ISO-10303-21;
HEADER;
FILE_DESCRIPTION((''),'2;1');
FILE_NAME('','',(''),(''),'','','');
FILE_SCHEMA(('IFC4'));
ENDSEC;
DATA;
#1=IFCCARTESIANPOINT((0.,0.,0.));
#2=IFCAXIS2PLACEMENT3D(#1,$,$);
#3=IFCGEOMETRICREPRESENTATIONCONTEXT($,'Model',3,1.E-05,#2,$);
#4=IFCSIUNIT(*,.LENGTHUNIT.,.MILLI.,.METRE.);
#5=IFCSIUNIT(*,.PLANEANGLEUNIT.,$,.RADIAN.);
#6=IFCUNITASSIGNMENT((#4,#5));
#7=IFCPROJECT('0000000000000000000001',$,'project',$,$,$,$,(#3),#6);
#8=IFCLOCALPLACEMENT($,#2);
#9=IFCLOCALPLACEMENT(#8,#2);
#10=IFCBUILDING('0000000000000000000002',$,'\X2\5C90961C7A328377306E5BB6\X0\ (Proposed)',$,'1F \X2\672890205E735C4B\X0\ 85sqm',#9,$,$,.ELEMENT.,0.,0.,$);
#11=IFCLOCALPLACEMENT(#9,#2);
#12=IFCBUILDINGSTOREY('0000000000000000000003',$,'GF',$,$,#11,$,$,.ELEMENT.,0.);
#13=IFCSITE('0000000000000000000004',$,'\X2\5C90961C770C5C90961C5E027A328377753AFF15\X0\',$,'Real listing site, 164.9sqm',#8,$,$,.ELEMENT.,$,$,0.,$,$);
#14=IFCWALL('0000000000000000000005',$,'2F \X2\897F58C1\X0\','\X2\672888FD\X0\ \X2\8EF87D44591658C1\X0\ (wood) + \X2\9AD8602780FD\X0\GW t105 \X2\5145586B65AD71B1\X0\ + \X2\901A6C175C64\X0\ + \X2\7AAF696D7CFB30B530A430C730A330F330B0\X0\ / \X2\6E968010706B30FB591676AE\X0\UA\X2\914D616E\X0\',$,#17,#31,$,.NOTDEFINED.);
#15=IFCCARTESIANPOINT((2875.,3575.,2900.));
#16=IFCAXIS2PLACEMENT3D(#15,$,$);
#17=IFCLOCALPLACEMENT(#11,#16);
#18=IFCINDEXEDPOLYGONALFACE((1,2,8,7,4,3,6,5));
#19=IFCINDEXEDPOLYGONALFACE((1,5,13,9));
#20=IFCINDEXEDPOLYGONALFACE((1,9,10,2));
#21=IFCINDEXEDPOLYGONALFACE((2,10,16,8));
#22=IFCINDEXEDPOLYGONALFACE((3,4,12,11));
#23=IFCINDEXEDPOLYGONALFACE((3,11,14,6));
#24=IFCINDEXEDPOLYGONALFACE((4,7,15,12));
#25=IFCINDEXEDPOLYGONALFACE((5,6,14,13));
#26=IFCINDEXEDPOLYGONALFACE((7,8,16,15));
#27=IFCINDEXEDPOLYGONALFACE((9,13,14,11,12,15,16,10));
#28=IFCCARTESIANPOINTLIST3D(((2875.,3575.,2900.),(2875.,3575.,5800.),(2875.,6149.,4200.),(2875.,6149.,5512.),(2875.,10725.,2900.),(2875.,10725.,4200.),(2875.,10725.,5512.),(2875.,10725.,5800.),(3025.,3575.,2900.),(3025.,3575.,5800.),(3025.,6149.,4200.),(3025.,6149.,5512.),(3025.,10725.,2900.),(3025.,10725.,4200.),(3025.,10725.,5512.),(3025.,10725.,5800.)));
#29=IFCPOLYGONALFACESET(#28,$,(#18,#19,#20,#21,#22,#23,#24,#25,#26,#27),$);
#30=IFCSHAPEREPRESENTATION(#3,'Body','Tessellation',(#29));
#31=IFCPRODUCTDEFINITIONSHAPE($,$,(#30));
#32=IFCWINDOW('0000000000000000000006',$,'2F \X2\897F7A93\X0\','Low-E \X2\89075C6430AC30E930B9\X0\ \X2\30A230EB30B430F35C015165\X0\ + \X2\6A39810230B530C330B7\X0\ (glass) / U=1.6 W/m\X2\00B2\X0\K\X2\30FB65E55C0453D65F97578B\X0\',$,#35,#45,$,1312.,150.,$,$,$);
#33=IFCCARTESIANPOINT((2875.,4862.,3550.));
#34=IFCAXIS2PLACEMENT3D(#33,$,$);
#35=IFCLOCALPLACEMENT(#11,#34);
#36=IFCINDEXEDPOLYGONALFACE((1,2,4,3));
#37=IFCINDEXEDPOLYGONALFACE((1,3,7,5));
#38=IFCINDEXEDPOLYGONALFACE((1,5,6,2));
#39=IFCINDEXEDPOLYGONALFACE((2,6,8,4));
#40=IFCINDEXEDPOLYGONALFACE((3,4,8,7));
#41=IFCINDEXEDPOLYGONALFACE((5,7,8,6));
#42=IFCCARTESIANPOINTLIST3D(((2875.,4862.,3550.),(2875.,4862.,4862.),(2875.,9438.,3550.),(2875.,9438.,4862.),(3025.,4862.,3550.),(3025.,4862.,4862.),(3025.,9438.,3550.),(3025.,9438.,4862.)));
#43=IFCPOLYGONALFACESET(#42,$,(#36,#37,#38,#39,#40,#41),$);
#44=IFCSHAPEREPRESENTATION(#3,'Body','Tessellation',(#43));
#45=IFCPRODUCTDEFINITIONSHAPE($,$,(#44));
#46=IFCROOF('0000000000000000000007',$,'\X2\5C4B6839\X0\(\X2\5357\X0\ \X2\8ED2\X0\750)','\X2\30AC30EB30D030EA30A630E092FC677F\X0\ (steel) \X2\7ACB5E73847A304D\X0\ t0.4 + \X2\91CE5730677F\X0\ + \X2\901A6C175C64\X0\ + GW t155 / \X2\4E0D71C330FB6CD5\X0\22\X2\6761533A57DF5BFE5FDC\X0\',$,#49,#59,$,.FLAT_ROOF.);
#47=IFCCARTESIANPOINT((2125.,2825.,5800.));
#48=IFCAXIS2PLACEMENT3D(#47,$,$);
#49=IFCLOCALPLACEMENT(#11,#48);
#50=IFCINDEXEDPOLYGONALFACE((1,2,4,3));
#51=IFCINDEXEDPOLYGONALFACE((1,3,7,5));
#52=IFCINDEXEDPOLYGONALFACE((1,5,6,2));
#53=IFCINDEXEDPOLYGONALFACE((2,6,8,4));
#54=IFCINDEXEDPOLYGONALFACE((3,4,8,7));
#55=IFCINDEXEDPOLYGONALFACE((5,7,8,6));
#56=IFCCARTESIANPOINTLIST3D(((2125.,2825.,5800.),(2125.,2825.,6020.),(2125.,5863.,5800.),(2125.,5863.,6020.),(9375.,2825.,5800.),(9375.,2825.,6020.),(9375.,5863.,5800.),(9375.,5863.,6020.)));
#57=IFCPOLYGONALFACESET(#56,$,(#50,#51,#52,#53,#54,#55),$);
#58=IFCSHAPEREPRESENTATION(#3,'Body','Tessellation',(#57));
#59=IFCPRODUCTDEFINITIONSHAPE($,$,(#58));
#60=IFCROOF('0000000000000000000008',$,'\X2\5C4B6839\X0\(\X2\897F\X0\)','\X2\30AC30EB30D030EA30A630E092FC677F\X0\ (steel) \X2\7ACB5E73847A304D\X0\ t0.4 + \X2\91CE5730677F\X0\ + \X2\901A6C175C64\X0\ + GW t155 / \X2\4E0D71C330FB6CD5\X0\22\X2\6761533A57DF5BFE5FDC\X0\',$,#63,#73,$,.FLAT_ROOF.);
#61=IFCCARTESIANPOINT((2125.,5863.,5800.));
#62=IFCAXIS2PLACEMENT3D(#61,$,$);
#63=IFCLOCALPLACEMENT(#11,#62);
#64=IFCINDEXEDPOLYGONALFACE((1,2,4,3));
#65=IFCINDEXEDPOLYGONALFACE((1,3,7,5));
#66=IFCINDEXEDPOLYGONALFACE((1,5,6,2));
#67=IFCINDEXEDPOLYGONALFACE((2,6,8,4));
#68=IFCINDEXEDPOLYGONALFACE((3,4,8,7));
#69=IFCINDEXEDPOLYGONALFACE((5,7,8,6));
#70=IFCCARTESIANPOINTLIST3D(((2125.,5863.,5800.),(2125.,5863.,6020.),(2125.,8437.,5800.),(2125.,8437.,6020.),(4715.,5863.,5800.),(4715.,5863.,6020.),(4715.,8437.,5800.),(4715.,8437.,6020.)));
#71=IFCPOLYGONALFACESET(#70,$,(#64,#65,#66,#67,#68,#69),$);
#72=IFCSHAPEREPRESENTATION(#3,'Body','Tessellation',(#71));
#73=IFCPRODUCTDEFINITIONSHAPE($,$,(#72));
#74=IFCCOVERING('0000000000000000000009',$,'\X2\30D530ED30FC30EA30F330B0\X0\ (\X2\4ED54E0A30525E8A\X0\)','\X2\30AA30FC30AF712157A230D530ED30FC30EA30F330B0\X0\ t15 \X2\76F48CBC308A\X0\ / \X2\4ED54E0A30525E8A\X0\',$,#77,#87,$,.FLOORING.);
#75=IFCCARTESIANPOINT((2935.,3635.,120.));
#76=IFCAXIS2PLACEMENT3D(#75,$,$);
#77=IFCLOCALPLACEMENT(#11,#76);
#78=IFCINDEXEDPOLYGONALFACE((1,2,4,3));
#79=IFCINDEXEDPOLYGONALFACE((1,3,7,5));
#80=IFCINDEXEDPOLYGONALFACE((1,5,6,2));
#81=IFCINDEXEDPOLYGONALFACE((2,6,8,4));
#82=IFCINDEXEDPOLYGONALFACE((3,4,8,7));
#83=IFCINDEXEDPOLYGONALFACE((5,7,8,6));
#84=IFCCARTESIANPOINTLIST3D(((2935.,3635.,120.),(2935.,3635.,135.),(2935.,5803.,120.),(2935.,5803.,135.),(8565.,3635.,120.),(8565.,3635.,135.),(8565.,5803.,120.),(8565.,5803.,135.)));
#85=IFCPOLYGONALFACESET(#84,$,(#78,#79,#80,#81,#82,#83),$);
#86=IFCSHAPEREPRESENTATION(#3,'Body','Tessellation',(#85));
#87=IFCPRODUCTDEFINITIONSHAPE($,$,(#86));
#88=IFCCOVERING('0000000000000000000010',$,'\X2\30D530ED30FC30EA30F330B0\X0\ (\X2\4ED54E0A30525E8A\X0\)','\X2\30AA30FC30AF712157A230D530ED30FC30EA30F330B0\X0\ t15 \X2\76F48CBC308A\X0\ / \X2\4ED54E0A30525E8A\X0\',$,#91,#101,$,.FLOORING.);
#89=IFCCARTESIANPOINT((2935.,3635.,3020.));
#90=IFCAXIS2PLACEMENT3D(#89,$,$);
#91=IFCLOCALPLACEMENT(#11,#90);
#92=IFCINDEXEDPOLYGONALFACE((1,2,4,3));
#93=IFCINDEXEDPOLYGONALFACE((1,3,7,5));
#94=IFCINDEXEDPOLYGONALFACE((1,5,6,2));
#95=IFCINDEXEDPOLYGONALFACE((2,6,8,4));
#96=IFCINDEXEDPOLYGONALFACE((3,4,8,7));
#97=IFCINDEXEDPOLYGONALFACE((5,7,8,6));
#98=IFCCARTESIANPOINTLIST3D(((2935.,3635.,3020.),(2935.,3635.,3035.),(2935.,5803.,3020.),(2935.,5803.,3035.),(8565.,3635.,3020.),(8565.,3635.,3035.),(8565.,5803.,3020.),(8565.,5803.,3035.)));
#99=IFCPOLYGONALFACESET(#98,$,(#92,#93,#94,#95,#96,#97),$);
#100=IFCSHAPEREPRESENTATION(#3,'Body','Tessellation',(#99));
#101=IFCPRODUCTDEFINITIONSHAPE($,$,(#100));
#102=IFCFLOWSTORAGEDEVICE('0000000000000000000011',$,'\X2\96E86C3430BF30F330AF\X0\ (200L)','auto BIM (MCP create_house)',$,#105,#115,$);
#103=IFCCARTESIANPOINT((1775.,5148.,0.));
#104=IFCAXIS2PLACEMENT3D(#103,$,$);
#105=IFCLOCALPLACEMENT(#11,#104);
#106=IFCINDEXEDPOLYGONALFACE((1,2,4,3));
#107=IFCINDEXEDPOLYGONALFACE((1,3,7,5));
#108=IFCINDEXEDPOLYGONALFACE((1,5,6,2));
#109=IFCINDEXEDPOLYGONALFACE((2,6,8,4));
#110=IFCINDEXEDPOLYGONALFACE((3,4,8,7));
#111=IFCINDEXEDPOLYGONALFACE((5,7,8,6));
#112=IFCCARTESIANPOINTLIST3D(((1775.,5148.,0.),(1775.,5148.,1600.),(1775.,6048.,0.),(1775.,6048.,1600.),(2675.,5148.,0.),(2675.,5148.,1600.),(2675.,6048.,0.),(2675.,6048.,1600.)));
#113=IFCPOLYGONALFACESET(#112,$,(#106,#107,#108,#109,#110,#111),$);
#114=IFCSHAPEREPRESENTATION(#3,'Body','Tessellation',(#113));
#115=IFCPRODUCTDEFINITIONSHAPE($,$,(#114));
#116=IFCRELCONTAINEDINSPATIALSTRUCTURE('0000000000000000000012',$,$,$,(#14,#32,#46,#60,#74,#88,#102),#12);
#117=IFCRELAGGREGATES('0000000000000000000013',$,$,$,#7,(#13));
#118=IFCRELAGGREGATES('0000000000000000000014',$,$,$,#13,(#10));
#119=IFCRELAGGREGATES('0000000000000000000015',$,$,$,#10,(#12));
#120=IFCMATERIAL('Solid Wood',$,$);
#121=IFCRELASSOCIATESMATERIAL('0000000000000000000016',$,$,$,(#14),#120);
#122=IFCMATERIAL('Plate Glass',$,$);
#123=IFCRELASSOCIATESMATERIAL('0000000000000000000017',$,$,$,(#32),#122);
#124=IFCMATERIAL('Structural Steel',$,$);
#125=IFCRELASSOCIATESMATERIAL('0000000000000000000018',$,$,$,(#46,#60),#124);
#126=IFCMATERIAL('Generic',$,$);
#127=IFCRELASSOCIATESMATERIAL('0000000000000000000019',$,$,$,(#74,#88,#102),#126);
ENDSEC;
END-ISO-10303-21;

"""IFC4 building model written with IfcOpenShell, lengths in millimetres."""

from ifc_helpers import new_model, si_unit, frame, frame_2d, origin, place, context, project, spatial, rectangle, extrude, material, element, fill, save


model = new_model("IFC4")

# Units and contexts
model_context = context("Model", 3, precision=1e-05, world=origin())
ifc_project = project(units=[si_unit("LENGTHUNIT", "METRE", prefix="MILLI"), si_unit("PLANEANGLEUNIT", "RADIAN")], contexts=[model_context])

# Site, building, storey
site_placement = place(None, origin())
site = spatial("IfcSite", under=ifc_project, at=site_placement, Name="岐阜県岐阜市稲荷町５", ObjectType="Real listing site, 164.9sqm", CompositionType="ELEMENT", RefElevation=0.0)
building_placement = place(site_placement, origin())
building = spatial("IfcBuilding", under=site, at=building_placement, Name="岐阜稲荷の家 (Proposed)", ObjectType="1F 木造平屋 85sqm", CompositionType="ELEMENT", ElevationOfRefHeight=0.0, ElevationOfTerrain=0.0)
storey_placement = place(building_placement, origin())
storey = spatial("IfcBuildingStorey", under=building, at=storey_placement, Name="GF", CompositionType="ELEMENT", Elevation=0.0)

# Shared definitions
ifc_material_1 = material(Name="Solid Wood")
ifc_material_2 = material(Name="Generic")

# Shared definitions
ifc_material_3 = material(Name="Plate Glass")

# Wall, opening, window
wall_1_placement = place(storey_placement, frame((2875.0, 3575.0, 2900.0)))
wall_1 = element("IfcWall", 1, at=wall_1_placement, inside=storey, material=ifc_material_1, Name="2F 西壁", Description="木製 軸組外壁 (wood) + 高性能GW t105 充填断熱 + 通気層 + 窯業系サイディング / 準耐火・外皮UA配慮", PredefinedType="NOTDEFINED", context=model_context, shape_type="SweptSolid", body=[
    extrude(rectangle(XDim=150.0, YDim=7150.0, at=frame_2d((75.0, 3575.0))), frame((2875.0, 3575.0, 2900.0)), (0.0, 0.0, 1.0), 2900.0),
])
opening_1_placement = place(storey_placement, frame((2875.0, 4862.0, 3550.0)))
opening_1 = element("IfcOpeningElement", 2, at=opening_1_placement, cuts=wall_1, PredefinedType="NOTDEFINED", context=model_context, shape_type="SweptSolid", body=[
    extrude(rectangle(XDim=150.0, YDim=4576.0, at=frame_2d((75.0, 2288.0))), frame((2875.0, 4862.0, 3550.0)), (0.0, 0.0, 1.0), 1312.0),
])
window_1_placement = place(storey_placement, frame((2875.0, 4862.0, 3550.0)))
window_1 = element("IfcWindow", 3, at=window_1_placement, inside=storey, material=ifc_material_3, Name="2F 西窓", Description="Low-E 複層ガラス アルゴン封入 + 樹脂サッシ (glass) / U=1.6 W/m²K・日射取得型", OverallHeight=1312.0, OverallWidth=150.0, context=model_context, shape_type="SweptSolid", body=[
    extrude(rectangle(XDim=150.0, YDim=4576.0, at=frame_2d((75.0, 2288.0))), frame((2875.0, 4862.0, 3550.0)), (0.0, 0.0, 1.0), 1312.0),
])
fill(opening_1, window_1)

# Roofs
ifc_material_4 = material(Name="Structural Steel")
roof_1_placement = place(storey_placement, frame((2125.0, 2825.0, 5800.0)))
element("IfcRoof", 4, at=roof_1_placement, inside=storey, material=ifc_material_4, Name="屋根(南 軒750)", Description="ガルバリウム鋼板 (steel) 立平葺き t0.4 + 野地板 + 通気層 + GW t155 / 不燃・法22条区域対応", PredefinedType="FLAT_ROOF", context=model_context, shape_type="SweptSolid", body=[
    extrude(rectangle(XDim=7250.0, YDim=3038.0, at=frame_2d((3625.0, 1519.0))), frame((2125.0, 2825.0, 5800.0)), (0.0, 0.0, 1.0), 220.0),
])
roof_2_placement = place(storey_placement, frame((2125.0, 5863.0, 5800.0)))
element("IfcRoof", 5, at=roof_2_placement, inside=storey, material=ifc_material_4, Name="屋根(西)", Description="ガルバリウム鋼板 (steel) 立平葺き t0.4 + 野地板 + 通気層 + GW t155 / 不燃・法22条区域対応", PredefinedType="FLAT_ROOF", context=model_context, shape_type="SweptSolid", body=[
    extrude(rectangle(XDim=2590.0, YDim=2574.0, at=frame_2d((1295.0, 1287.0))), frame((2125.0, 5863.0, 5800.0)), (0.0, 0.0, 1.0), 220.0),
])

# Coverings
covering_1_placement = place(storey_placement, frame((2935.0, 3635.0, 120.0)))
element("IfcCovering", 6, at=covering_1_placement, inside=storey, material=ifc_material_2, Name="フローリング (仕上げ床)", Description="オーク無垢フローリング t15 直貼り / 仕上げ床", PredefinedType="FLOORING", context=model_context, shape_type="SweptSolid", body=[
    extrude(rectangle(XDim=5630.0, YDim=2168.0, at=frame_2d((2815.0, 1084.0))), frame((2935.0, 3635.0, 120.0)), (0.0, 0.0, 1.0), 15.0),
])
covering_2_placement = place(storey_placement, frame((2935.0, 3635.0, 3020.0)))
element("IfcCovering", 7, at=covering_2_placement, inside=storey, material=ifc_material_2, Name="フローリング (仕上げ床)", Description="オーク無垢フローリング t15 直貼り / 仕上げ床", PredefinedType="FLOORING", context=model_context, shape_type="SweptSolid", body=[
    extrude(rectangle(XDim=5630.0, YDim=2168.0, at=frame_2d((2815.0, 1084.0))), frame((2935.0, 3635.0, 3020.0)), (0.0, 0.0, 1.0), 15.0),
])

# Flow storage device
flow_storage_device_placement = place(storey_placement, frame((1775.0, 5148.0, 0.0)))
element("IfcFlowStorageDevice", 8, at=flow_storage_device_placement, inside=storey, material=ifc_material_2, Name="雨水タンク (200L)", Description="auto BIM (MCP create_house)", context=model_context, shape_type="SweptSolid", body=[
    extrude(rectangle(XDim=900.0, YDim=900.0, at=frame_2d((450.0, 450.0))), frame((1775.0, 5148.0, 0.0)), (0.0, 0.0, 1.0), 1600.0),
])

save(model, "model.ifc")
